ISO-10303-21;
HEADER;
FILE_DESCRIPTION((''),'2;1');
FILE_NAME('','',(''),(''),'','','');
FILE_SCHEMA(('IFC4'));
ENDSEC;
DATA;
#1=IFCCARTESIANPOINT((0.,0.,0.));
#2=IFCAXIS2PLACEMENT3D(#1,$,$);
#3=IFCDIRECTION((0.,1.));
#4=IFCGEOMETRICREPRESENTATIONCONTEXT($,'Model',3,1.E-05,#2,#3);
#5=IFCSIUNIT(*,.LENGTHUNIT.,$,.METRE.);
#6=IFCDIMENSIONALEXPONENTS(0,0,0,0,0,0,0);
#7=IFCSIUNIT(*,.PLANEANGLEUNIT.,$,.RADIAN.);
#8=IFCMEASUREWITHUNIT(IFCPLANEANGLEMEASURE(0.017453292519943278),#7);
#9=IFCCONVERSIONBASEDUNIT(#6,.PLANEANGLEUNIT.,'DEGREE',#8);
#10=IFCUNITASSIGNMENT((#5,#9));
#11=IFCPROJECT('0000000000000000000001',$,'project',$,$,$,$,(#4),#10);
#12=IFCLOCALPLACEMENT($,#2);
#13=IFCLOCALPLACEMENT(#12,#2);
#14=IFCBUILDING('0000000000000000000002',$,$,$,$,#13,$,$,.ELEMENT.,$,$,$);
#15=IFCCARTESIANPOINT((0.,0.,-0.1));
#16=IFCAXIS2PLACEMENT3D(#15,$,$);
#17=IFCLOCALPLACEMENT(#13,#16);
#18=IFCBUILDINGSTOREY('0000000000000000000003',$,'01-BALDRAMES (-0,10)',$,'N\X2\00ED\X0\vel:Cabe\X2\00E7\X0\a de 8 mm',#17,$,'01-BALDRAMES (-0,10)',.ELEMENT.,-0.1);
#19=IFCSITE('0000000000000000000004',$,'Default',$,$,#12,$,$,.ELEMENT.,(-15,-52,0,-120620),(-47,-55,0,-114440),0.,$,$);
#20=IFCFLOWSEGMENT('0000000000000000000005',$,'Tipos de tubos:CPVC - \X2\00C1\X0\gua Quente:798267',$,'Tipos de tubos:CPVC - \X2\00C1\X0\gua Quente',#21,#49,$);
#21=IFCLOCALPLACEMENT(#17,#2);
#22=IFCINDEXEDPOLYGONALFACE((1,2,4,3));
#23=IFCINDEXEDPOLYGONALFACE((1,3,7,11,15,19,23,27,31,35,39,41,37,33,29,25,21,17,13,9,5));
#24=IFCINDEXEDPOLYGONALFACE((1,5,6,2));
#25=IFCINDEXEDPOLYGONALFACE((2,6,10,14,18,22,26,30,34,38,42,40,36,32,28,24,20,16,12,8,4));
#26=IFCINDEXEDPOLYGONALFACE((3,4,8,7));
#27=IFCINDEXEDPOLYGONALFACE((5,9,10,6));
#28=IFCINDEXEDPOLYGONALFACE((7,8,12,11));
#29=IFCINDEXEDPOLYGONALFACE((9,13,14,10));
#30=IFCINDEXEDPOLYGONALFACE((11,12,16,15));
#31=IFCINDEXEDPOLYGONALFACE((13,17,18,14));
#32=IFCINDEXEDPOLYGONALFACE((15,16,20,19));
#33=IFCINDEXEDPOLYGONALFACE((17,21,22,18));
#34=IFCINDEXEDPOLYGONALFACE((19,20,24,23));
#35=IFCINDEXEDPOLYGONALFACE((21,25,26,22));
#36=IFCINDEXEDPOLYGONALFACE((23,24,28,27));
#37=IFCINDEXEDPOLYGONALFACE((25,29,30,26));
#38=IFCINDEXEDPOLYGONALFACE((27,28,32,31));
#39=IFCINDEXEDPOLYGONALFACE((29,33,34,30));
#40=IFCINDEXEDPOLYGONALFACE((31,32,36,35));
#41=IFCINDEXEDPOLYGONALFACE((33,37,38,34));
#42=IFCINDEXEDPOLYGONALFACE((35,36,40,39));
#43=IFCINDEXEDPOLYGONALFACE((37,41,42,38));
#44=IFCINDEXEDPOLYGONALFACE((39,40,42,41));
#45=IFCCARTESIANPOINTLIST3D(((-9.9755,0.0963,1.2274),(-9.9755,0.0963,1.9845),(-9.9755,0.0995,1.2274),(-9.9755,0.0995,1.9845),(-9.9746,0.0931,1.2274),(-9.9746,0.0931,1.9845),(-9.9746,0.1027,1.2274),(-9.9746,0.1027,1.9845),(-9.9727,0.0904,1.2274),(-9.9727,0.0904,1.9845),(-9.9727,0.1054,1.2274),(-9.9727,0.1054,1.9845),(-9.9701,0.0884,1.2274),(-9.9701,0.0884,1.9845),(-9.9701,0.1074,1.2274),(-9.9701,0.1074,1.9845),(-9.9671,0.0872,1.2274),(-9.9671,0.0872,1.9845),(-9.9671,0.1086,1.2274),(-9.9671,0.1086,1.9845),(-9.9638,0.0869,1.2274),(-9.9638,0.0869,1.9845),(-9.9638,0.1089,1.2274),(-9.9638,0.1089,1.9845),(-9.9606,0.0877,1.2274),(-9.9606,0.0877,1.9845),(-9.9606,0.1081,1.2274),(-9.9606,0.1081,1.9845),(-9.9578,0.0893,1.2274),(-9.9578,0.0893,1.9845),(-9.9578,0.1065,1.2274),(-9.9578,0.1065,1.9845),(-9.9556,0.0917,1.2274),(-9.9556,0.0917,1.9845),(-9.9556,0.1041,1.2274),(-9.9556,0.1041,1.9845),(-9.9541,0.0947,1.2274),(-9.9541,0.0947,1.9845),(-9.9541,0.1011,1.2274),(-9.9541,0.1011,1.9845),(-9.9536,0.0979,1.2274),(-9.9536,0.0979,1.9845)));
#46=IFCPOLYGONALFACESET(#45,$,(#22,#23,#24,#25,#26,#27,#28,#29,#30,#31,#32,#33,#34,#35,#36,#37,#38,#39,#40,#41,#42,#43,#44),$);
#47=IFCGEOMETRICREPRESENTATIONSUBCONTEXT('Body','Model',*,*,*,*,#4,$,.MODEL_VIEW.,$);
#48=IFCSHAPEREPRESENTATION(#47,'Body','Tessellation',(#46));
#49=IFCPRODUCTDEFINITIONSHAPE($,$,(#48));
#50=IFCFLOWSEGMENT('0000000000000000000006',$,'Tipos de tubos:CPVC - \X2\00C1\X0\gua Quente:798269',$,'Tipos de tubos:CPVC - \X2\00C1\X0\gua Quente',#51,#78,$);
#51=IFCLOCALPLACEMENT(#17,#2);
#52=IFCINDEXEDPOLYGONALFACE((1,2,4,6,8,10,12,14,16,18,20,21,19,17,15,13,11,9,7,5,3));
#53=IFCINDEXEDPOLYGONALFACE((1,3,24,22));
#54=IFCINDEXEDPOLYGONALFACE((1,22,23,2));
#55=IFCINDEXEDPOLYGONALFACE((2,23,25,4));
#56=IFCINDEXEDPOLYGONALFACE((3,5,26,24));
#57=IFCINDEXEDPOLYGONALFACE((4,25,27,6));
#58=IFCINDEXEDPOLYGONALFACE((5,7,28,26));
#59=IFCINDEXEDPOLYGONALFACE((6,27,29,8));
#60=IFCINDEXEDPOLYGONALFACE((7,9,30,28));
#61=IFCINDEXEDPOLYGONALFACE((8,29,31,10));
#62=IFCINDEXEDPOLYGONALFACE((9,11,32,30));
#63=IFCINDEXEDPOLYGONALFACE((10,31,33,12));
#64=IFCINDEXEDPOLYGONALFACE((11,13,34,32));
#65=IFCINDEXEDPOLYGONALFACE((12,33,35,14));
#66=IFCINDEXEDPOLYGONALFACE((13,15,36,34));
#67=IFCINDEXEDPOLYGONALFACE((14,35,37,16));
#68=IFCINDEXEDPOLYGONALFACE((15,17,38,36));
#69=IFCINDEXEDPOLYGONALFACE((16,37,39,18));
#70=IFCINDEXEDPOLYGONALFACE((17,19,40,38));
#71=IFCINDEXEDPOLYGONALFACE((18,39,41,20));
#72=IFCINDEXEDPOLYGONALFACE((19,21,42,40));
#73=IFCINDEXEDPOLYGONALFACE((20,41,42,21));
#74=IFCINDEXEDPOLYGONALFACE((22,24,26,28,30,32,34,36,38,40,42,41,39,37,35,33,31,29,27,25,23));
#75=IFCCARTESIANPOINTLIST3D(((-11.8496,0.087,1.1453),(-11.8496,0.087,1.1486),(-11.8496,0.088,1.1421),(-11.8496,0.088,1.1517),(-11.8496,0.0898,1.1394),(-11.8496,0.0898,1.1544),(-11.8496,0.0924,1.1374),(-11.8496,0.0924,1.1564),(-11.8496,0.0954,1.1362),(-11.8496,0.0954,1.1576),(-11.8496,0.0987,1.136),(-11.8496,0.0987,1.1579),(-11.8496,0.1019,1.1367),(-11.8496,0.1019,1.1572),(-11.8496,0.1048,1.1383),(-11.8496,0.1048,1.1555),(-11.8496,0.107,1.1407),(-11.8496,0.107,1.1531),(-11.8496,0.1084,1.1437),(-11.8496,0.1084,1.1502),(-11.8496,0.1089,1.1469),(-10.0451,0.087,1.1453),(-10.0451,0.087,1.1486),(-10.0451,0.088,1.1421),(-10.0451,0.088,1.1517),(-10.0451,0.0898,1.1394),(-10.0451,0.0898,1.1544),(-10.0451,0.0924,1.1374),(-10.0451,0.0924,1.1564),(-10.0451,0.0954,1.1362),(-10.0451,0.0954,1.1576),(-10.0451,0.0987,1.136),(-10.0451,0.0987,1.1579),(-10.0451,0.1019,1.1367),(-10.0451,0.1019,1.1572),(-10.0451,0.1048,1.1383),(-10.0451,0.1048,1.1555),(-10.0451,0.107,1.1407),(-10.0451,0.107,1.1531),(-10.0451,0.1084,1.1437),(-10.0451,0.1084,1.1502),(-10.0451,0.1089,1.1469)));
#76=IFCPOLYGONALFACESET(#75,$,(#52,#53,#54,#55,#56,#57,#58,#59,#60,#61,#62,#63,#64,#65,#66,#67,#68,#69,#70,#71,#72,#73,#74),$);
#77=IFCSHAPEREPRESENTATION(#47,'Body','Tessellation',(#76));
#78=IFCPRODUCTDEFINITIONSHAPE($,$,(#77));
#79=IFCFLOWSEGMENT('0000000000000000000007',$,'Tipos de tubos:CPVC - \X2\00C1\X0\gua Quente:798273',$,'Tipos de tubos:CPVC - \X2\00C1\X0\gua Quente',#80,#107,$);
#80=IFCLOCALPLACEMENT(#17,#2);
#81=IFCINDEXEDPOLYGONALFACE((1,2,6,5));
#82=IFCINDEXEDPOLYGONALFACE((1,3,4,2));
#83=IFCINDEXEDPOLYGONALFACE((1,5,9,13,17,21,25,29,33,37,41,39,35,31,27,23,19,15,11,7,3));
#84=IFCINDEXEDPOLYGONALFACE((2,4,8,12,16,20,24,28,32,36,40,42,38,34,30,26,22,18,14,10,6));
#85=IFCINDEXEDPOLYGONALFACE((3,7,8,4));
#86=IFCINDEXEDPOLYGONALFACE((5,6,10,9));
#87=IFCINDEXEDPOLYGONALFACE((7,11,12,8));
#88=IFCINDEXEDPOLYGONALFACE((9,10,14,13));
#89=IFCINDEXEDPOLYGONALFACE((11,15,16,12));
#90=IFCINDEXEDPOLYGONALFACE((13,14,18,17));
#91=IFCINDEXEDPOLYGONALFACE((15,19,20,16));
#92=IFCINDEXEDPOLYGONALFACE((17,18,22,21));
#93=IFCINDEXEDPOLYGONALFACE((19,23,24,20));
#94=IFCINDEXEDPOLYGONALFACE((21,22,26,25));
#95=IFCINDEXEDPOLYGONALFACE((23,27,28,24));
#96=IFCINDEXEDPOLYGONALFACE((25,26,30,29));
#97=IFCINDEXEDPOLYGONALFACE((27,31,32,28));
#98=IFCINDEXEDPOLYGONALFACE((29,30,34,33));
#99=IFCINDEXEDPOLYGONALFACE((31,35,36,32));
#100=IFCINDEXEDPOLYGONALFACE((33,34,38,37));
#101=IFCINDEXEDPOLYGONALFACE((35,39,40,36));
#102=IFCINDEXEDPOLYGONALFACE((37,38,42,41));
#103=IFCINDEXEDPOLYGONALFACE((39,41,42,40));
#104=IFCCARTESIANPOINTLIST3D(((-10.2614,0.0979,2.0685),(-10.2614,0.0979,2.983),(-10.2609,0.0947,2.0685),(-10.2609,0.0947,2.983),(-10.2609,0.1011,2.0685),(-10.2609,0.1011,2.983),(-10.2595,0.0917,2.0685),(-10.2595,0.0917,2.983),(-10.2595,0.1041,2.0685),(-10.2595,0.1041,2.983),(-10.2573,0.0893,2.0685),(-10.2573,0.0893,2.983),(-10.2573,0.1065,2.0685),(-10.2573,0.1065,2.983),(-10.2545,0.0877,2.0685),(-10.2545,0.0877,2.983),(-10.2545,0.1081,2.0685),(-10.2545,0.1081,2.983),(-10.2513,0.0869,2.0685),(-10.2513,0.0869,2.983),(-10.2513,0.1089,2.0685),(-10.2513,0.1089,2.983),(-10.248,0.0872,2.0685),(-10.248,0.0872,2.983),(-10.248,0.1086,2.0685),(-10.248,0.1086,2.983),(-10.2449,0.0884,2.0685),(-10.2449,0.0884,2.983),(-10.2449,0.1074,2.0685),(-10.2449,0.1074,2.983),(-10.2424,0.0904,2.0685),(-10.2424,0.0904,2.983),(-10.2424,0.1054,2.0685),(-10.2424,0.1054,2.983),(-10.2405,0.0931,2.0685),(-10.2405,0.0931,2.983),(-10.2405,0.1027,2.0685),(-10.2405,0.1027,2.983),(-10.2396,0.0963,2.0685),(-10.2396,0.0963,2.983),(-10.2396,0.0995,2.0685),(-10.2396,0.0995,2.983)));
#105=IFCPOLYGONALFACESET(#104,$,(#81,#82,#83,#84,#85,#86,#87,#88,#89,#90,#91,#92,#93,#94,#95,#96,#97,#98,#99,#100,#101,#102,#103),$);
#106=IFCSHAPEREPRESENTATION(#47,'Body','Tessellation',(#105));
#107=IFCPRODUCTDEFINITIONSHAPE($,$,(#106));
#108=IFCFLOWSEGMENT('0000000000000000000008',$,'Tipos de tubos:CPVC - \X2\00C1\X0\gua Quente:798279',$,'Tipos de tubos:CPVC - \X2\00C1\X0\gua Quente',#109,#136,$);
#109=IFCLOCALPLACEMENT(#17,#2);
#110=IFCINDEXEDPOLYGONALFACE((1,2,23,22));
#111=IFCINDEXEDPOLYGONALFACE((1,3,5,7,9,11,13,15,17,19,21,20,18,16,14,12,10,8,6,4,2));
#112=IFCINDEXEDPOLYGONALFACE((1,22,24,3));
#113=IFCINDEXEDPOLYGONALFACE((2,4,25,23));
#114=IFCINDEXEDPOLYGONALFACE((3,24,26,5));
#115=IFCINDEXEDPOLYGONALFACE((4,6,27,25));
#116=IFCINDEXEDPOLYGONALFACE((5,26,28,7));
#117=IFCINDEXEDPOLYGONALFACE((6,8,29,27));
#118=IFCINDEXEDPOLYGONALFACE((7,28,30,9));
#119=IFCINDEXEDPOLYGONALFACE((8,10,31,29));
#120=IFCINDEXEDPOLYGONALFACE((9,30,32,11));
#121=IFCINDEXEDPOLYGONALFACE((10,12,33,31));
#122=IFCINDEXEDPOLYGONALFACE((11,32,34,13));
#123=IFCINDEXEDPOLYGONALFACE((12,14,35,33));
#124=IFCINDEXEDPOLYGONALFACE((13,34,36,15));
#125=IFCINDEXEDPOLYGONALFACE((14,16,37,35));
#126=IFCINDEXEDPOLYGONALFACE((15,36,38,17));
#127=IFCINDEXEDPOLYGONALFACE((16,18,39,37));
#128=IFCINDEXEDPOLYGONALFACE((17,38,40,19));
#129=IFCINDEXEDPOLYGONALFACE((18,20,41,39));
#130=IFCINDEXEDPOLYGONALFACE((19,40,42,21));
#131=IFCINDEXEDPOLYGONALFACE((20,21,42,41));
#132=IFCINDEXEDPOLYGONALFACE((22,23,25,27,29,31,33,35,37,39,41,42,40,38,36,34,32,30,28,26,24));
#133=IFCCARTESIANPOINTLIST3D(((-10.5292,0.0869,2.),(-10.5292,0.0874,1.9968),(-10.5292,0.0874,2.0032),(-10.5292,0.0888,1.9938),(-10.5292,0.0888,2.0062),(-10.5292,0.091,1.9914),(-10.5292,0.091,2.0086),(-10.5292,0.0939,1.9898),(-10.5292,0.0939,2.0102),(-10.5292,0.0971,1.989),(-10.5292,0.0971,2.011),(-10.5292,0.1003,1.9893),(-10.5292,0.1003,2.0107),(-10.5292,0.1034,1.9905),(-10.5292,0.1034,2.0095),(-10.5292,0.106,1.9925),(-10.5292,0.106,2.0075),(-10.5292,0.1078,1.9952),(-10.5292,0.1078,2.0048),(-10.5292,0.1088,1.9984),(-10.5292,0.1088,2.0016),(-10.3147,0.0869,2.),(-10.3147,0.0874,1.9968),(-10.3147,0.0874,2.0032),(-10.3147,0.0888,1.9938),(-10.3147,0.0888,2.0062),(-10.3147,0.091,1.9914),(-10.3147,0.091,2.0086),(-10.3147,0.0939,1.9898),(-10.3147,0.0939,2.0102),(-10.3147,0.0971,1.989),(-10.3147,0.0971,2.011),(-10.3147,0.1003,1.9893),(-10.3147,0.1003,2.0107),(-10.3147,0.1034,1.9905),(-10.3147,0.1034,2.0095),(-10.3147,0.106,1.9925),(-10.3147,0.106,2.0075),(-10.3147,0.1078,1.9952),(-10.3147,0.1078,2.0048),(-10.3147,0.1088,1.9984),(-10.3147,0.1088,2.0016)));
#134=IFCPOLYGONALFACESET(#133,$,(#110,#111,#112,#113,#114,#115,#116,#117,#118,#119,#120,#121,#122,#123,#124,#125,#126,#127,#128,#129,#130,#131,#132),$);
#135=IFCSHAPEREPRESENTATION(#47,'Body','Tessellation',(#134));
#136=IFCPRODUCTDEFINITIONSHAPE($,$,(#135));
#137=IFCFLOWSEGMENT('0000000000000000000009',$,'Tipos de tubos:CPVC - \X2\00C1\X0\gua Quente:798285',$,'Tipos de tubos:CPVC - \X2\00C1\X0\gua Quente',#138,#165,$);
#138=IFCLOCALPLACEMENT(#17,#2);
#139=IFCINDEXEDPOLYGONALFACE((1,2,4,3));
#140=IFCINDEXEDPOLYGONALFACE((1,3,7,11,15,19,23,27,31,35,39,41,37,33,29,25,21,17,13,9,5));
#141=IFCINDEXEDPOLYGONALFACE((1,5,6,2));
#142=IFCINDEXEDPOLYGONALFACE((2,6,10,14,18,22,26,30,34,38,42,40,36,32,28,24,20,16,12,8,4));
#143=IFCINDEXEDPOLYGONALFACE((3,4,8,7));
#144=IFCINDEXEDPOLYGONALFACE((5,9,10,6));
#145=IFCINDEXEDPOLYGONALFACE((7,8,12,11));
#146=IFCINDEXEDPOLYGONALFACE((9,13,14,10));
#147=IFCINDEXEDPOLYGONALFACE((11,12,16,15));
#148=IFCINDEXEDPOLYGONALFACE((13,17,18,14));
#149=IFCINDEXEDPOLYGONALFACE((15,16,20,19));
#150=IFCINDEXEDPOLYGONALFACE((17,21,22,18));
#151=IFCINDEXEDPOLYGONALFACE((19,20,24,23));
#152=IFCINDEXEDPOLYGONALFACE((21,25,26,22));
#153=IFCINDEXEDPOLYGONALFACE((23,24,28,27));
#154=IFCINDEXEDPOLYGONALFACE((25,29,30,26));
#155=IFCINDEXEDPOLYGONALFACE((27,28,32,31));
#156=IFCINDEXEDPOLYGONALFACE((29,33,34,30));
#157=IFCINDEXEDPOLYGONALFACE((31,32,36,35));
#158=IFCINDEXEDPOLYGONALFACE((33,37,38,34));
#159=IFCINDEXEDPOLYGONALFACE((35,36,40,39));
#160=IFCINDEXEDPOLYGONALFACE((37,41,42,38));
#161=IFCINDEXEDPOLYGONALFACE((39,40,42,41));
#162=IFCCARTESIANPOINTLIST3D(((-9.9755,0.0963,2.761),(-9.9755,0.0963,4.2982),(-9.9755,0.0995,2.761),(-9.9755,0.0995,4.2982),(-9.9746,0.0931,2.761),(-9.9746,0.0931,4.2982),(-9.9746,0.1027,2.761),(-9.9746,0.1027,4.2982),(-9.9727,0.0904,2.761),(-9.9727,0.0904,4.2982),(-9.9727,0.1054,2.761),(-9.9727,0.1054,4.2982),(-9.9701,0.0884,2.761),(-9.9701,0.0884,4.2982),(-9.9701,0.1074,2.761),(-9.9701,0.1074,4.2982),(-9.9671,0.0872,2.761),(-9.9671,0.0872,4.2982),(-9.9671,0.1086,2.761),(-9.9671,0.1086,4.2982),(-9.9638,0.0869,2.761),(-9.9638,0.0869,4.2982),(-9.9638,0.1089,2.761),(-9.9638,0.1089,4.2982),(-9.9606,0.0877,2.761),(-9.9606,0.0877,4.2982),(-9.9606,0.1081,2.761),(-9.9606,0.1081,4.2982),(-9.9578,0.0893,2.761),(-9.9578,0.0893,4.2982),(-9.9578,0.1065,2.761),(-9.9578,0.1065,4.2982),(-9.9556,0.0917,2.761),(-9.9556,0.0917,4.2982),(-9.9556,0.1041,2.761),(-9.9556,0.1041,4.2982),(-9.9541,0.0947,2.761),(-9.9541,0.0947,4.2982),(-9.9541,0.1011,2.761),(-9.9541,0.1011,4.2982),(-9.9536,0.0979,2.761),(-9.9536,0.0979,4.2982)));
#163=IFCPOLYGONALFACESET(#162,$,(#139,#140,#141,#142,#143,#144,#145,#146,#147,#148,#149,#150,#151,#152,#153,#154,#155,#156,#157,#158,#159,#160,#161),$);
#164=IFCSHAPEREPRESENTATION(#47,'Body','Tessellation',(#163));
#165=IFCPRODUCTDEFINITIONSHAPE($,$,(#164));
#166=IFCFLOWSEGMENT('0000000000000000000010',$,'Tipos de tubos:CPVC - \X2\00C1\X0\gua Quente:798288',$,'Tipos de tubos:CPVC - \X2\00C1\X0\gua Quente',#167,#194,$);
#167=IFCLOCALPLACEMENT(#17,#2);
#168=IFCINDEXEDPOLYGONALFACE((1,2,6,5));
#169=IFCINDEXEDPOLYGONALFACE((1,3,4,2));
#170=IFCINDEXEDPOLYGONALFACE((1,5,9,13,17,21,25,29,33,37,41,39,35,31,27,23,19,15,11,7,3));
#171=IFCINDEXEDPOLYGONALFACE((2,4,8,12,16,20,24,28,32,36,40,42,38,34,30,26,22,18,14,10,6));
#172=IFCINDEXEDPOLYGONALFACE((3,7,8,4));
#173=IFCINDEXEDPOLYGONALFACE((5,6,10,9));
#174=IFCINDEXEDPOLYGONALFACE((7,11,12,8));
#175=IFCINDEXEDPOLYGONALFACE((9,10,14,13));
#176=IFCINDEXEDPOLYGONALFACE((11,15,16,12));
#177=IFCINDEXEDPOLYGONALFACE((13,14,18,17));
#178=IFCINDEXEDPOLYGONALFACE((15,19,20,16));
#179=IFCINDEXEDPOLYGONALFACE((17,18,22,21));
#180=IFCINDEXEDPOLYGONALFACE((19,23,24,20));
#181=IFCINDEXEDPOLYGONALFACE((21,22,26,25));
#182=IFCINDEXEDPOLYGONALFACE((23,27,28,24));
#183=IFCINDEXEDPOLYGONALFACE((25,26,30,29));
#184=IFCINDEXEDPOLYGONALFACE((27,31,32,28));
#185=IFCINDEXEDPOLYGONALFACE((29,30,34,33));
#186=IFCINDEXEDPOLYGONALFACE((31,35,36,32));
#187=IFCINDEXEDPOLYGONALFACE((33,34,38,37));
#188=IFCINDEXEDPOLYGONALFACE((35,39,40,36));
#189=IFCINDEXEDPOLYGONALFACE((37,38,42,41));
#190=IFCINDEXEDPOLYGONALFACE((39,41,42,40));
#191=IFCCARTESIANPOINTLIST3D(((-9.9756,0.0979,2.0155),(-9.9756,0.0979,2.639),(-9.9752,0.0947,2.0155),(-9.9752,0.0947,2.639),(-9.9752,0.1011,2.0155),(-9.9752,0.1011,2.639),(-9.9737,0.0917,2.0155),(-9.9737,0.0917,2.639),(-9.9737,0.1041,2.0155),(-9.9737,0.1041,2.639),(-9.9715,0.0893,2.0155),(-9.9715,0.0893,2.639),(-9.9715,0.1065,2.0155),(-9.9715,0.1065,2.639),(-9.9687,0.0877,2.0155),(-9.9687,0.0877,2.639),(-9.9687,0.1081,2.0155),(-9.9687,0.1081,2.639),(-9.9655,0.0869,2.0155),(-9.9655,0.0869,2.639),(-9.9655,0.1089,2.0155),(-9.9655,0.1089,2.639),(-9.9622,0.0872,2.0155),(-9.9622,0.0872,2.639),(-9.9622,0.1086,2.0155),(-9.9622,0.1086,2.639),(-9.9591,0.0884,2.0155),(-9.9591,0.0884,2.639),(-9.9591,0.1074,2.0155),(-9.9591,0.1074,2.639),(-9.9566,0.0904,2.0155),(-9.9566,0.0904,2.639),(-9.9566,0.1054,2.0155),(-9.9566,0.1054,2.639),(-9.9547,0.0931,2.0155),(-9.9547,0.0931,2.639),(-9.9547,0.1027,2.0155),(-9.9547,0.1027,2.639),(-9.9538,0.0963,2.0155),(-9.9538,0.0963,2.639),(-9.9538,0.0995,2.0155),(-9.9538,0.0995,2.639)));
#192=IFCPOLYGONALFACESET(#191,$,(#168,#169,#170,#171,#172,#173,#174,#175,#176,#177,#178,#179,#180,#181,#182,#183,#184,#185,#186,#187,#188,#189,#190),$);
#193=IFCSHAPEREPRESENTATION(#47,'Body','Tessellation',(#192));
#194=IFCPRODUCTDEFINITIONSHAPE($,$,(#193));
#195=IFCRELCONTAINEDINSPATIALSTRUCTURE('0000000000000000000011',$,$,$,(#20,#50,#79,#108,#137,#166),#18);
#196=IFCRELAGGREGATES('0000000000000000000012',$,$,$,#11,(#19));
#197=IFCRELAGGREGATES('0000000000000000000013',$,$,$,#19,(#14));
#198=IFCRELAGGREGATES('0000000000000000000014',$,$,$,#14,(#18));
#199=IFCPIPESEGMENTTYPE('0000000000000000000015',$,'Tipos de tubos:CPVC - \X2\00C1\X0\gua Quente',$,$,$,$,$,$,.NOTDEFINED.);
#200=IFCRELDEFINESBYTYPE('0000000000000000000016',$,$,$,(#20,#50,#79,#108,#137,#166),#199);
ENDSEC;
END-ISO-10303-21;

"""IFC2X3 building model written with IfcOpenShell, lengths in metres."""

from ifc_helpers import new_model, entity, si_unit, converted_unit, direction, frame, frame_2d, origin, origin_2d_with_axis, place, context, subcontext, project, spatial, circle, extrude, type_object, element, save


model = new_model("IFC2X3")

# Units and contexts
model_context = context("Model", 3, precision=1e-05, world=origin(), true_north=direction((0.0, 1.0)))
body_context = subcontext(model_context, "Body", "Model", "MODEL_VIEW")
ifc_project = project(units=[si_unit("LENGTHUNIT", "METRE"), converted_unit("PLANEANGLEUNIT", "DEGREE", entity("IfcPlaneAngleMeasure", 0.017453292519943278), si_unit("PLANEANGLEUNIT", "RADIAN"), dimensions=[0, 0, 0, 0, 0, 0, 0])], contexts=[model_context])

# Site, building, storey
site_placement = place(None, origin())
site = spatial("IfcSite", under=ifc_project, at=site_placement, Name="Default", CompositionType="ELEMENT", RefLatitude=(-15, -52, 0, -120620), RefLongitude=(-47, -55, 0, -114440), RefElevation=0.0)
building_placement = place(site_placement, origin())
building = spatial("IfcBuilding", under=site, at=building_placement, CompositionType="ELEMENT")
storey_placement = place(building_placement, frame((0.0, 0.0, -0.1)))
storey = spatial("IfcBuildingStorey", under=building, at=storey_placement, Name="01-BALDRAMES (-0,10)", ObjectType="Nível:Cabeça de 8 mm", LongName="01-BALDRAMES (-0,10)", CompositionType="ELEMENT", Elevation=-0.1)

# Flow segments
pipe_segment_type_1 = type_object("IfcPipeSegmentType", Name="Tipos de tubos:CPVC - Água Quente", PredefinedType="NOTDEFINED")
flow_segment_1_placement = place(storey_placement, origin())
element("IfcFlowSegment", 1, at=flow_segment_1_placement, inside=storey, type_object=pipe_segment_type_1, Name="Tipos de tubos:CPVC - Água Quente:798267", ObjectType="Tipos de tubos:CPVC - Água Quente", context=body_context, shape_type="SweptSolid", body=[
    extrude(circle(Radius=0.011, at=frame_2d((0.0, 0.0), x_axis=(1.0, 0.0))), frame((-9.9646, 0.0979, 1.2274)), (0.0, 0.0, 1.0), 0.7571),
])
flow_segment_2_placement = place(storey_placement, origin())
element("IfcFlowSegment", 2, at=flow_segment_2_placement, inside=storey, type_object=pipe_segment_type_1, Name="Tipos de tubos:CPVC - Água Quente:798269", ObjectType="Tipos de tubos:CPVC - Água Quente", context=body_context, shape_type="SweptSolid", body=[
    extrude(circle(Radius=0.011, at=frame_2d((0.0, 0.0), x_axis=(1.0, 0.0))), frame((-11.8496, 0.0979, 1.1469), z_axis=(1.0, 0.0, 0.0), x_axis=(0.0, 1.0, 0.0)), (0.0, 0.0, 1.0), 1.8045),
])
flow_segment_3_placement = place(storey_placement, origin())
element("IfcFlowSegment", 3, at=flow_segment_3_placement, inside=storey, type_object=pipe_segment_type_1, Name="Tipos de tubos:CPVC - Água Quente:798273", ObjectType="Tipos de tubos:CPVC - Água Quente", context=body_context, shape_type="SweptSolid", body=[
    extrude(circle(Radius=0.011, at=origin_2d_with_axis()), frame((-10.2504, 0.0979, 2.0685), z_axis=(0.0, 0.0, 1.0), x_axis=(-1.0, 0.0, 0.0)), (0.0, 0.0, 1.0), 0.9145),
])
flow_segment_4_placement = place(storey_placement, origin())
element("IfcFlowSegment", 4, at=flow_segment_4_placement, inside=storey, type_object=pipe_segment_type_1, Name="Tipos de tubos:CPVC - Água Quente:798279", ObjectType="Tipos de tubos:CPVC - Água Quente", context=body_context, shape_type="SweptSolid", body=[
    extrude(circle(Radius=0.011, at=frame_2d((0.0, 0.0), x_axis=(1.0, 0.0))), frame((-10.5292, 0.0979, 2.0), z_axis=(1.0, 0.0, 0.0), x_axis=(0.0, -1.0, 0.0)), (0.0, 0.0, 1.0), 0.2145),
])
flow_segment_5_placement = place(storey_placement, origin())
element("IfcFlowSegment", 5, at=flow_segment_5_placement, inside=storey, type_object=pipe_segment_type_1, Name="Tipos de tubos:CPVC - Água Quente:798285", ObjectType="Tipos de tubos:CPVC - Água Quente", context=body_context, shape_type="SweptSolid", body=[
    extrude(circle(Radius=0.011, at=origin_2d_with_axis()), frame((-9.9646, 0.0979, 2.761)), (0.0, 0.0, 1.0), 1.5373),
])
flow_segment_6_placement = place(storey_placement, origin())
element("IfcFlowSegment", 6, at=flow_segment_6_placement, inside=storey, type_object=pipe_segment_type_1, Name="Tipos de tubos:CPVC - Água Quente:798288", ObjectType="Tipos de tubos:CPVC - Água Quente", context=body_context, shape_type="SweptSolid", body=[
    extrude(circle(Radius=0.011, at=origin_2d_with_axis()), frame((-9.9646, 0.0979, 2.0155), z_axis=(0.0, 0.0, 1.0), x_axis=(-1.0, 0.0, 0.0)), (0.0, 0.0, 1.0), 0.6235),
])

save(model, "model.ifc")
